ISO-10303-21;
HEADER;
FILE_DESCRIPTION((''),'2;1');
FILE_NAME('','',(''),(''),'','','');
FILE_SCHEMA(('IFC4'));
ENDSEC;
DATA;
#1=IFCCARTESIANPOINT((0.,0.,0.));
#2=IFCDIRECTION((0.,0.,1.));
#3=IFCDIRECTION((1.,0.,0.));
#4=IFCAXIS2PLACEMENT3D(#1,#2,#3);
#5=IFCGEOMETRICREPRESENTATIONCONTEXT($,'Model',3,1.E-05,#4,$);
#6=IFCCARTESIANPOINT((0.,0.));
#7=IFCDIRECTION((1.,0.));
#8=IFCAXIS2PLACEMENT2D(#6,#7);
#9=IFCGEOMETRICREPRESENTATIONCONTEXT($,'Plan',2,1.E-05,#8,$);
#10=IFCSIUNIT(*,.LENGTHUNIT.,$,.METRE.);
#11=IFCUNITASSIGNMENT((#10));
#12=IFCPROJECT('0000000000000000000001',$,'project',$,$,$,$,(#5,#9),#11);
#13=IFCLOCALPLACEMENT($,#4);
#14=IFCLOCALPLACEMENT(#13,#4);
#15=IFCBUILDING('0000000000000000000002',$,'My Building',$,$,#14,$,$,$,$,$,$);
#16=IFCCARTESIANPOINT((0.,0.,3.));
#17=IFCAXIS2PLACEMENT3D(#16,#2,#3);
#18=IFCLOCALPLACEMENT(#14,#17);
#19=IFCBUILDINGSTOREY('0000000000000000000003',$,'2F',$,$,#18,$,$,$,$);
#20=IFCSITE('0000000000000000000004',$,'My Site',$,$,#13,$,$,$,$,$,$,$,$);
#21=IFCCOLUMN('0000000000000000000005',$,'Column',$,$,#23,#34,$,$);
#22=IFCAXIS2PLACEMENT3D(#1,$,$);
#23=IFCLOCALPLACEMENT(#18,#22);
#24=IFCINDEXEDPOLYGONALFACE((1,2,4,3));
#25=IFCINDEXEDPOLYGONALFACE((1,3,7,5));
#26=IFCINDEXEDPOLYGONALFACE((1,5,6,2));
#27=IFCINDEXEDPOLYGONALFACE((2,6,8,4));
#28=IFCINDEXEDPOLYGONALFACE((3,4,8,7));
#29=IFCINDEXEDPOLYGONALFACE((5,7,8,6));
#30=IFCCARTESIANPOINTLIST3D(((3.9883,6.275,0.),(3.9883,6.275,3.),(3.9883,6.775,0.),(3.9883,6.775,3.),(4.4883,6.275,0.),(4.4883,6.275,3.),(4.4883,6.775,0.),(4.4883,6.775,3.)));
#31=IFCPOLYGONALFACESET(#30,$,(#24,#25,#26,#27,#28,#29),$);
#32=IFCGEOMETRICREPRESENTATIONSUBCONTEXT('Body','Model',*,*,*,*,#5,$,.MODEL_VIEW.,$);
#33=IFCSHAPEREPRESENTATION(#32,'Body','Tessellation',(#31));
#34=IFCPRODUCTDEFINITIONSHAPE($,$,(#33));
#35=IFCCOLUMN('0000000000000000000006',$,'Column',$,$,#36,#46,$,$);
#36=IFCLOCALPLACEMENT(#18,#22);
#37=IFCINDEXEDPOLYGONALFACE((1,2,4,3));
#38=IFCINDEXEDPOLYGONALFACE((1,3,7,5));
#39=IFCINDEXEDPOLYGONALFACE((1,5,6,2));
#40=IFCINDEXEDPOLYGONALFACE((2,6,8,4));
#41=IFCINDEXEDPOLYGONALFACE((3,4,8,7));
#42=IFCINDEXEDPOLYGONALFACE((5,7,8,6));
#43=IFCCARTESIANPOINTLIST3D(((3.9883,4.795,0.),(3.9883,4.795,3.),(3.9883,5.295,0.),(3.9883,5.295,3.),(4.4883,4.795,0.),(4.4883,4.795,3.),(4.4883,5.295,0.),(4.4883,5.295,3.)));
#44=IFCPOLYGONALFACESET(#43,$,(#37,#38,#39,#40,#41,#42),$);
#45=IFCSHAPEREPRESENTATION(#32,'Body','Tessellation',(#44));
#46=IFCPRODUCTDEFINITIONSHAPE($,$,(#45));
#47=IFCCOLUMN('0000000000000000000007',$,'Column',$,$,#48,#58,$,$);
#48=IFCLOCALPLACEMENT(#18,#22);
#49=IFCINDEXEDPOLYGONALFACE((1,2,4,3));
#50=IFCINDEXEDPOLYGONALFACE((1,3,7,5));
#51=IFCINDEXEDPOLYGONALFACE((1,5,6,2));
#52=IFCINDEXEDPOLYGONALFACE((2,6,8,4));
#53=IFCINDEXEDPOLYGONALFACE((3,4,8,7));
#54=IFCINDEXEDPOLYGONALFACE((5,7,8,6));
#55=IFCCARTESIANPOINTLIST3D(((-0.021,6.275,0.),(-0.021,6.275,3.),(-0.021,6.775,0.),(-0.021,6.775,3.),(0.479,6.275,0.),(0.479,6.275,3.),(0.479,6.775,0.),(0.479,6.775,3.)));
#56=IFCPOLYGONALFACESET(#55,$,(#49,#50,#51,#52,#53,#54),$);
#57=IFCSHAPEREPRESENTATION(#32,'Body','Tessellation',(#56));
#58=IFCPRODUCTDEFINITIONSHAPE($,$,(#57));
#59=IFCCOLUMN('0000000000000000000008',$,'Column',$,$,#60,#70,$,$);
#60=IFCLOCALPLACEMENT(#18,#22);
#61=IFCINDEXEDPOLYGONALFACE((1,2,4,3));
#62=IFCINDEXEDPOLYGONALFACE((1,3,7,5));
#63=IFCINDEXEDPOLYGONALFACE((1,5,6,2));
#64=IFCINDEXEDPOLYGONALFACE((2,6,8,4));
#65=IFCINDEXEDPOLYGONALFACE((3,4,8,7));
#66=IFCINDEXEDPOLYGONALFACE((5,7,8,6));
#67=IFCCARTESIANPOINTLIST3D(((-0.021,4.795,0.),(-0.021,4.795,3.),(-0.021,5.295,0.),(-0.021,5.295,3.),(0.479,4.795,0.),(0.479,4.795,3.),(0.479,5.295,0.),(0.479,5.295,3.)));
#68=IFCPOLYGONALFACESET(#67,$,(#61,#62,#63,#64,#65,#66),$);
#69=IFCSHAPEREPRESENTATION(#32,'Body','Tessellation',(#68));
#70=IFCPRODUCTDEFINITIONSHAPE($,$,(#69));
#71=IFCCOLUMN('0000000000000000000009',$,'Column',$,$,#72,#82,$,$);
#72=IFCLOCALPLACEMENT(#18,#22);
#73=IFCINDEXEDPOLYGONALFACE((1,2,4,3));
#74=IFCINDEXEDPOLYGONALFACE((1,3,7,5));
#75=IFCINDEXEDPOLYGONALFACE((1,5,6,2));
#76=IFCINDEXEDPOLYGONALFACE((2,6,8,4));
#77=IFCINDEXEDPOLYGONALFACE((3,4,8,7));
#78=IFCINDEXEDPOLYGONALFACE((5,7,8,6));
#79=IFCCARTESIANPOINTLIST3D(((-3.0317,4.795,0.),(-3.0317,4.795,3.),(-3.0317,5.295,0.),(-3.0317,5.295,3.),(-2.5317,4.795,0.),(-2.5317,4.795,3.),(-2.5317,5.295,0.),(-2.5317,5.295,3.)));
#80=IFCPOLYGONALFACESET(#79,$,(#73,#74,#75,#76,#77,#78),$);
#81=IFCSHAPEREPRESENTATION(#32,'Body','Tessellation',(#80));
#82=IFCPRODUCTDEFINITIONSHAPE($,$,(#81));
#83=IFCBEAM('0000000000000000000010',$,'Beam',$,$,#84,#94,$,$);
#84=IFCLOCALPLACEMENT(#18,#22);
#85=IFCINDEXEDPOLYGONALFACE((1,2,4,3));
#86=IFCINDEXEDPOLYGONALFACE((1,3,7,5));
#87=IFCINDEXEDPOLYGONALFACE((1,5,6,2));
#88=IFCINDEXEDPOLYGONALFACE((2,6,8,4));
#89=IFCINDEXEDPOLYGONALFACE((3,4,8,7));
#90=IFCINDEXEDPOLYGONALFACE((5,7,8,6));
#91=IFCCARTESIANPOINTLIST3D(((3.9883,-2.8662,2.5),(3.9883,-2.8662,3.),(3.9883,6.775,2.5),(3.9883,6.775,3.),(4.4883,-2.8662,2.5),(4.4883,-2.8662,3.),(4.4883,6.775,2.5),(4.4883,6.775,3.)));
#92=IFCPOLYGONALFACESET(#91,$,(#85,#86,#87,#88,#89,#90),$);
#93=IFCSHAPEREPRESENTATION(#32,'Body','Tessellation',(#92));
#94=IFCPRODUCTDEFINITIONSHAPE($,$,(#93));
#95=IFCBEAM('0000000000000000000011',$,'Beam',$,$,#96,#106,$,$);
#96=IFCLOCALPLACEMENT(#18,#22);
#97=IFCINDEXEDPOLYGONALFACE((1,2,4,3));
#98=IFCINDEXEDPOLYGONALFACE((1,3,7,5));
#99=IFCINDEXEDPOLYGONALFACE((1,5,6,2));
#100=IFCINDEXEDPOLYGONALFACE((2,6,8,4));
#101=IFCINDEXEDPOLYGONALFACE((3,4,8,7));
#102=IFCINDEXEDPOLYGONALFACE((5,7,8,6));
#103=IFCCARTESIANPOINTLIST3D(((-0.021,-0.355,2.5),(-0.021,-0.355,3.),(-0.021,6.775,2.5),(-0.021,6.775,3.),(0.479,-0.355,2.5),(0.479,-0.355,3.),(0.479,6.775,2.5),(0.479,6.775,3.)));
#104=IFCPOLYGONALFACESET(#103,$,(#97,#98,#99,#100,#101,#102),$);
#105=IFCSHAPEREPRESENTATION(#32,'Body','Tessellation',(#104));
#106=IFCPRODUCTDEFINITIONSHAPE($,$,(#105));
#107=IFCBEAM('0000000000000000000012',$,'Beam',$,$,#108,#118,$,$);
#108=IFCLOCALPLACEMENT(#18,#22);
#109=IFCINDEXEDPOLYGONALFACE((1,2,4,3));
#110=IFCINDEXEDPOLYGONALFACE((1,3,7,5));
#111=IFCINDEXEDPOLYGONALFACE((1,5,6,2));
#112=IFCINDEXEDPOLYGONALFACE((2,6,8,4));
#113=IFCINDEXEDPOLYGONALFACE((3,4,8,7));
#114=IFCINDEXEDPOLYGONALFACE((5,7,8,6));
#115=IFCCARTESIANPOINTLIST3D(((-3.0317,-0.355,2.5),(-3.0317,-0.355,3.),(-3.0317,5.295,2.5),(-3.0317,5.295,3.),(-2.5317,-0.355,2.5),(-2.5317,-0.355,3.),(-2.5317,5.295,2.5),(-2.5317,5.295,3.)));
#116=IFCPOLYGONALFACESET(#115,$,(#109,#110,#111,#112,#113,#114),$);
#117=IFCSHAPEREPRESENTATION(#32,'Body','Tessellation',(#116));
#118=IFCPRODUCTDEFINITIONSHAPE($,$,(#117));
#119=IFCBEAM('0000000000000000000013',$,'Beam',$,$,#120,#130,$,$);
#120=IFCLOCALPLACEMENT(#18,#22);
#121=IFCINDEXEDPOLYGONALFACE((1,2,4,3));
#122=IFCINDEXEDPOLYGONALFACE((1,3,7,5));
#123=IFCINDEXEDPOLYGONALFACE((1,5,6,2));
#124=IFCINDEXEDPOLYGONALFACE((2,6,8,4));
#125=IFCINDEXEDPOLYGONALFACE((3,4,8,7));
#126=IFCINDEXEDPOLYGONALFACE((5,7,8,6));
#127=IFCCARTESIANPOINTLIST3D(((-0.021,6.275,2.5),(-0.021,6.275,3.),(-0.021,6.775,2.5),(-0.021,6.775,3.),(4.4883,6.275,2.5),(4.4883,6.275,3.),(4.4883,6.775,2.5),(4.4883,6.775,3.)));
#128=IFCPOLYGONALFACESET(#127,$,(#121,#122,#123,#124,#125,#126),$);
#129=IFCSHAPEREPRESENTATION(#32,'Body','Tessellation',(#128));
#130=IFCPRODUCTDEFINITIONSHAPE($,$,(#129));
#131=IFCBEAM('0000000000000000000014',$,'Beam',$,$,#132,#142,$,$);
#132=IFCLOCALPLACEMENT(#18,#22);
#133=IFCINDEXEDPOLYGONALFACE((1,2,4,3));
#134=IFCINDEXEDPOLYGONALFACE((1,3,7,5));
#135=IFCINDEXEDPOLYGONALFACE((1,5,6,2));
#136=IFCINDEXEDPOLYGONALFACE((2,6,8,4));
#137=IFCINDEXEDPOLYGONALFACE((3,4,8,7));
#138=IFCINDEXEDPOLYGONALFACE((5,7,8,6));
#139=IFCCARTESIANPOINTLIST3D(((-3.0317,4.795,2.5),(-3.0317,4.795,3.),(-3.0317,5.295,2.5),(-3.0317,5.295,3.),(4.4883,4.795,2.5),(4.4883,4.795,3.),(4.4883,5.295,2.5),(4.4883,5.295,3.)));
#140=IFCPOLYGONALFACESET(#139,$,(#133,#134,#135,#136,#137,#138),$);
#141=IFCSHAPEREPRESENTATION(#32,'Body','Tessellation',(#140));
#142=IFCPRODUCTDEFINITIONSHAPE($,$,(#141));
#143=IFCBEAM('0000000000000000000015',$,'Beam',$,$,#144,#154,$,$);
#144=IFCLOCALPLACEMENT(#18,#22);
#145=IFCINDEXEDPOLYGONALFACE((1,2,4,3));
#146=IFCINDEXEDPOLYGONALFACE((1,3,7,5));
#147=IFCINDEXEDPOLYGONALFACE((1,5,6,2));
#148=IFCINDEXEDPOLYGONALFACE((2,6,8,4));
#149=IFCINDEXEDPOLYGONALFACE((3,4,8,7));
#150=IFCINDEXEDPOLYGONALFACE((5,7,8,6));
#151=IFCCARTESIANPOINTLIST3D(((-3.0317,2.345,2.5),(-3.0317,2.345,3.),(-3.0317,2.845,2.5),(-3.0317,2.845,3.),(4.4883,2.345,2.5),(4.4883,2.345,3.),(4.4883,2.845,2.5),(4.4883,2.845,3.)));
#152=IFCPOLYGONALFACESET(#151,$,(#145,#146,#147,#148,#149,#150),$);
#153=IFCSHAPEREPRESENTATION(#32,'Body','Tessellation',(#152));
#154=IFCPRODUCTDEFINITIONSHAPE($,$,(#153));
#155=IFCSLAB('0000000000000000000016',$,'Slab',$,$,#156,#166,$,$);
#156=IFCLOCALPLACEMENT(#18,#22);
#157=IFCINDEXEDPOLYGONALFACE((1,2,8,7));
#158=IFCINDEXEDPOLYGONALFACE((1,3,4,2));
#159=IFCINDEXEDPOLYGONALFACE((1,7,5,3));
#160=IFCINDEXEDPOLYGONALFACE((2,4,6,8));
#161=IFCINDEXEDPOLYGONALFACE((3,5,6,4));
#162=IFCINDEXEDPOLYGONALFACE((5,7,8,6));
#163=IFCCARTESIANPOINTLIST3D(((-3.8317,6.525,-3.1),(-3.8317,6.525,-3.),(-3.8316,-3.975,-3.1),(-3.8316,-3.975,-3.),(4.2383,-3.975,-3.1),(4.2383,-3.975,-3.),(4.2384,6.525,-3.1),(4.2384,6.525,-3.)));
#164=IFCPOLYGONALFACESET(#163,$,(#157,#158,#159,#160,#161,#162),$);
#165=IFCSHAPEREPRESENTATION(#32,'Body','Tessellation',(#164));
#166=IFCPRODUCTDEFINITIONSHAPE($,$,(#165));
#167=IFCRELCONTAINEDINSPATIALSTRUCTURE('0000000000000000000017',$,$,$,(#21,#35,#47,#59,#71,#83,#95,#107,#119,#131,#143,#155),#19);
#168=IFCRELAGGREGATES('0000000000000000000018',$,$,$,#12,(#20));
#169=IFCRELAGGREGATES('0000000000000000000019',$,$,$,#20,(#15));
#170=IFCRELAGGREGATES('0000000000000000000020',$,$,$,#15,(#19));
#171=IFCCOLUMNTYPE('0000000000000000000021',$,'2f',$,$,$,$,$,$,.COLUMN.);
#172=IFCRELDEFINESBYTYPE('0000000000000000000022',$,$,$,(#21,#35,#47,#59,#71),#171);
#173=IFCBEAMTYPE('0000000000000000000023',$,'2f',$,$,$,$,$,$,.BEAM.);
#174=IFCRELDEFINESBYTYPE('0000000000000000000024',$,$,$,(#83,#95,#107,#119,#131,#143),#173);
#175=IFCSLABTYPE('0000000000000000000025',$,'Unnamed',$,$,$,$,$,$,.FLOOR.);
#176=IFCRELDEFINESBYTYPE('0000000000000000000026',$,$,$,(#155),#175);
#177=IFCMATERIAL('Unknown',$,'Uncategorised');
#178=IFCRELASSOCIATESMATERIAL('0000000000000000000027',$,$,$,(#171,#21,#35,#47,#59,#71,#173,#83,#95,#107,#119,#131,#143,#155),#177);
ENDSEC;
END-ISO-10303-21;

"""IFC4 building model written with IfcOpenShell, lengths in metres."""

from ifc_helpers import new_model, si_unit, frame, origin_with_axes, origin_2d_with_axis, place, context, subcontext, project, spatial, indexed_curve, rectangle, outline, extrude, material, material_profile, profile_set, profile_usage, type_object, element, save


model = new_model("IFC4")

# Units and contexts
model_context = context("Model", 3, precision=1e-05, world=origin_with_axes())
plan_context = context("Plan", 2, precision=1e-05, world=origin_2d_with_axis())
body_context_1 = subcontext(model_context, "Body", "Model", "MODEL_VIEW")
ifc_project = project(units=[si_unit("LENGTHUNIT", "METRE")], contexts=[model_context, plan_context])

# Site, building, storey
site_placement = place(None, origin_with_axes())
site = spatial("IfcSite", under=ifc_project, at=site_placement, Name="My Site")
building_placement = place(site_placement, origin_with_axes())
building = spatial("IfcBuilding", under=site, at=building_placement, Name="My Building")
storey_placement = place(building_placement, frame((0.0, 0.0, 3.0), z_axis=(0.0, 0.0, 1.0), x_axis=(1.0, 0.0, 0.0)))
storey = spatial("IfcBuildingStorey", under=building, at=storey_placement, Name="2F")

# Columns
ifc_material = material(Name="Unknown", Category="Uncategorised")
ifc_material_profile_1 = material_profile(ifc_material, rectangle(XDim=0.5, YDim=0.5))
ifc_profile_set_1 = profile_set([ifc_material_profile_1])
ifc_profile_usage_1 = profile_usage(ifc_profile_set_1, cardinal=5)
column_type = type_object("IfcColumnType", Name="2f", PredefinedType="COLUMN", material=ifc_profile_set_1)
column_1_placement = place(storey_placement, frame((4.2383, 6.525, 0.0), z_axis=(0.0, 0.0, 1.0), x_axis=(1.0, 0.0, 0.0)))
element("IfcColumn", 1, at=column_1_placement, inside=storey, type_object=column_type, material=ifc_profile_usage_1, Name="Column", context=body_context_1, shape_type="SweptSolid", body=[
    extrude(rectangle(XDim=0.5, YDim=0.5), origin_with_axes(), (0.0, 0.0, 1.0), 3.0),
])
ifc_profile_usage_2 = profile_usage(ifc_profile_set_1, cardinal=5)
column_2_placement = place(storey_placement, frame((4.2383, 5.045, 0.0), z_axis=(0.0, 0.0, 1.0), x_axis=(1.0, 0.0, 0.0)))
element("IfcColumn", 2, at=column_2_placement, inside=storey, type_object=column_type, material=ifc_profile_usage_2, Name="Column", context=body_context_1, shape_type="SweptSolid", body=[
    extrude(rectangle(XDim=0.5, YDim=0.5), origin_with_axes(), (0.0, 0.0, 1.0), 3.0),
])
ifc_profile_usage_3 = profile_usage(ifc_profile_set_1, cardinal=5)
column_3_placement = place(storey_placement, frame((0.229, 6.525, 0.0), z_axis=(0.0, 0.0, 1.0), x_axis=(1.0, 0.0, 0.0)))
element("IfcColumn", 3, at=column_3_placement, inside=storey, type_object=column_type, material=ifc_profile_usage_3, Name="Column", context=body_context_1, shape_type="SweptSolid", body=[
    extrude(rectangle(XDim=0.5, YDim=0.5), origin_with_axes(), (0.0, 0.0, 1.0), 3.0),
])
ifc_profile_usage_4 = profile_usage(ifc_profile_set_1, cardinal=5)
column_4_placement = place(storey_placement, frame((0.229, 5.045, 0.0), z_axis=(0.0, 0.0, 1.0), x_axis=(1.0, 0.0, 0.0)))
element("IfcColumn", 4, at=column_4_placement, inside=storey, type_object=column_type, material=ifc_profile_usage_4, Name="Column", context=body_context_1, shape_type="SweptSolid", body=[
    extrude(rectangle(XDim=0.5, YDim=0.5), origin_with_axes(), (0.0, 0.0, 1.0), 3.0),
])
ifc_profile_usage_5 = profile_usage(ifc_profile_set_1, cardinal=5)
column_5_placement = place(storey_placement, frame((-2.7817, 5.045, 0.0), z_axis=(0.0, 0.0, 1.0), x_axis=(1.0, 0.0, 0.0)))
element("IfcColumn", 5, at=column_5_placement, inside=storey, type_object=column_type, material=ifc_profile_usage_5, Name="Column", context=body_context_1, shape_type="SweptSolid", body=[
    extrude(rectangle(XDim=0.5, YDim=0.5), origin_with_axes(), (0.0, 0.0, 1.0), 3.0),
])

# Beams
ifc_material_profile_2 = material_profile(ifc_material, rectangle(XDim=0.5, YDim=0.5))
ifc_profile_set_2 = profile_set([ifc_material_profile_2])
ifc_profile_usage_6 = profile_usage(ifc_profile_set_2, cardinal=5)
beam_type = type_object("IfcBeamType", Name="2f", PredefinedType="BEAM", material=ifc_profile_set_2)
beam_1_placement = place(storey_placement, frame((4.2383, 6.775, 2.75), z_axis=(0.0, -1.0, 0.0), x_axis=(1.0, 0.0, 0.0)))
element("IfcBeam", 6, at=beam_1_placement, inside=storey, type_object=beam_type, material=ifc_profile_usage_6, Name="Beam", context=body_context_1, shape_type="SweptSolid", body=[
    extrude(rectangle(XDim=0.5, YDim=0.5), origin_with_axes(), (0.0, 0.0, 1.0), 9.6412),
])
ifc_profile_usage_7 = profile_usage(ifc_profile_set_2, cardinal=5)
beam_2_placement = place(storey_placement, frame((0.229, 6.775, 2.75), z_axis=(0.0, -1.0, 0.0), x_axis=(1.0, 0.0, 0.0)))
element("IfcBeam", 7, at=beam_2_placement, inside=storey, type_object=beam_type, material=ifc_profile_usage_7, Name="Beam", context=body_context_1, shape_type="SweptSolid", body=[
    extrude(rectangle(XDim=0.5, YDim=0.5), origin_with_axes(), (0.0, 0.0, 1.0), 7.13),
])
ifc_profile_usage_8 = profile_usage(ifc_profile_set_2, cardinal=5)
beam_3_placement = place(storey_placement, frame((-2.7817, 5.295, 2.75), z_axis=(0.0, -1.0, 0.0), x_axis=(1.0, 0.0, 0.0)))
element("IfcBeam", 8, at=beam_3_placement, inside=storey, type_object=beam_type, material=ifc_profile_usage_8, Name="Beam", context=body_context_1, shape_type="SweptSolid", body=[
    extrude(rectangle(XDim=0.5, YDim=0.5), origin_with_axes(), (0.0, 0.0, 1.0), 5.65),
])
ifc_profile_usage_9 = profile_usage(ifc_profile_set_2, cardinal=5)
beam_4_placement = place(storey_placement, frame((-0.021, 6.525, 2.75), z_axis=(1.0, 0.0, 0.0), x_axis=(0.0, 1.0, 0.0)))
element("IfcBeam", 9, at=beam_4_placement, inside=storey, type_object=beam_type, material=ifc_profile_usage_9, Name="Beam", context=body_context_1, shape_type="SweptSolid", body=[
    extrude(rectangle(XDim=0.5, YDim=0.5), origin_with_axes(), (0.0, 0.0, 1.0), 4.5094),
])
ifc_profile_usage_10 = profile_usage(ifc_profile_set_2, cardinal=5)
beam_5_placement = place(storey_placement, frame((4.4883, 5.045, 2.75), z_axis=(-1.0, 0.0, 0.0), x_axis=(0.0, -1.0, 0.0)))
element("IfcBeam", 10, at=beam_5_placement, inside=storey, type_object=beam_type, material=ifc_profile_usage_10, Name="Beam", context=body_context_1, shape_type="SweptSolid", body=[
    extrude(rectangle(XDim=0.5, YDim=0.5), origin_with_axes(), (0.0, 0.0, 1.0), 7.52),
])
ifc_profile_usage_11 = profile_usage(ifc_profile_set_2, cardinal=5)
beam_6_placement = place(storey_placement, frame((4.4883, 2.595, 2.75), z_axis=(-1.0, 0.0, 0.0), x_axis=(0.0, -1.0, 0.0)))
element("IfcBeam", 11, at=beam_6_placement, inside=storey, type_object=beam_type, material=ifc_profile_usage_11, Name="Beam", context=body_context_1, shape_type="SweptSolid", body=[
    extrude(rectangle(XDim=0.5, YDim=0.5), origin_with_axes(), (0.0, 0.0, 1.0), 7.52),
])

# Slab
slab_type = type_object("IfcSlabType", Name="Unnamed", PredefinedType="FLOOR")
for number, where, z_axis, x_axis, name in (
    (12, (4.2384, 6.525, -3.0), (0.0, 0.0, 1.0), (1.0, 0.0, 0.0), "Slab"),
):
    element("IfcSlab", number, at=place(storey_placement, frame(where, z_axis=z_axis, x_axis=x_axis)), inside=storey, type_object=slab_type, material=ifc_material, Name=name, context=body_context_1, shape_type="SweptSolid", body=[
        extrude(outline(indexed_curve([(0.0, 0.0), (-8.07, 0.0), (-8.07, -10.5), (0.0, -10.5), (0.0, 0.0)])), frame((0.0, 0.0, -0.1), z_axis=(0.0, 0.0, 1.0), x_axis=(1.0, 0.0, 0.0)), (0.0, 0.0, 1.0), 0.1),
    ])

save(model, "model.ifc")
